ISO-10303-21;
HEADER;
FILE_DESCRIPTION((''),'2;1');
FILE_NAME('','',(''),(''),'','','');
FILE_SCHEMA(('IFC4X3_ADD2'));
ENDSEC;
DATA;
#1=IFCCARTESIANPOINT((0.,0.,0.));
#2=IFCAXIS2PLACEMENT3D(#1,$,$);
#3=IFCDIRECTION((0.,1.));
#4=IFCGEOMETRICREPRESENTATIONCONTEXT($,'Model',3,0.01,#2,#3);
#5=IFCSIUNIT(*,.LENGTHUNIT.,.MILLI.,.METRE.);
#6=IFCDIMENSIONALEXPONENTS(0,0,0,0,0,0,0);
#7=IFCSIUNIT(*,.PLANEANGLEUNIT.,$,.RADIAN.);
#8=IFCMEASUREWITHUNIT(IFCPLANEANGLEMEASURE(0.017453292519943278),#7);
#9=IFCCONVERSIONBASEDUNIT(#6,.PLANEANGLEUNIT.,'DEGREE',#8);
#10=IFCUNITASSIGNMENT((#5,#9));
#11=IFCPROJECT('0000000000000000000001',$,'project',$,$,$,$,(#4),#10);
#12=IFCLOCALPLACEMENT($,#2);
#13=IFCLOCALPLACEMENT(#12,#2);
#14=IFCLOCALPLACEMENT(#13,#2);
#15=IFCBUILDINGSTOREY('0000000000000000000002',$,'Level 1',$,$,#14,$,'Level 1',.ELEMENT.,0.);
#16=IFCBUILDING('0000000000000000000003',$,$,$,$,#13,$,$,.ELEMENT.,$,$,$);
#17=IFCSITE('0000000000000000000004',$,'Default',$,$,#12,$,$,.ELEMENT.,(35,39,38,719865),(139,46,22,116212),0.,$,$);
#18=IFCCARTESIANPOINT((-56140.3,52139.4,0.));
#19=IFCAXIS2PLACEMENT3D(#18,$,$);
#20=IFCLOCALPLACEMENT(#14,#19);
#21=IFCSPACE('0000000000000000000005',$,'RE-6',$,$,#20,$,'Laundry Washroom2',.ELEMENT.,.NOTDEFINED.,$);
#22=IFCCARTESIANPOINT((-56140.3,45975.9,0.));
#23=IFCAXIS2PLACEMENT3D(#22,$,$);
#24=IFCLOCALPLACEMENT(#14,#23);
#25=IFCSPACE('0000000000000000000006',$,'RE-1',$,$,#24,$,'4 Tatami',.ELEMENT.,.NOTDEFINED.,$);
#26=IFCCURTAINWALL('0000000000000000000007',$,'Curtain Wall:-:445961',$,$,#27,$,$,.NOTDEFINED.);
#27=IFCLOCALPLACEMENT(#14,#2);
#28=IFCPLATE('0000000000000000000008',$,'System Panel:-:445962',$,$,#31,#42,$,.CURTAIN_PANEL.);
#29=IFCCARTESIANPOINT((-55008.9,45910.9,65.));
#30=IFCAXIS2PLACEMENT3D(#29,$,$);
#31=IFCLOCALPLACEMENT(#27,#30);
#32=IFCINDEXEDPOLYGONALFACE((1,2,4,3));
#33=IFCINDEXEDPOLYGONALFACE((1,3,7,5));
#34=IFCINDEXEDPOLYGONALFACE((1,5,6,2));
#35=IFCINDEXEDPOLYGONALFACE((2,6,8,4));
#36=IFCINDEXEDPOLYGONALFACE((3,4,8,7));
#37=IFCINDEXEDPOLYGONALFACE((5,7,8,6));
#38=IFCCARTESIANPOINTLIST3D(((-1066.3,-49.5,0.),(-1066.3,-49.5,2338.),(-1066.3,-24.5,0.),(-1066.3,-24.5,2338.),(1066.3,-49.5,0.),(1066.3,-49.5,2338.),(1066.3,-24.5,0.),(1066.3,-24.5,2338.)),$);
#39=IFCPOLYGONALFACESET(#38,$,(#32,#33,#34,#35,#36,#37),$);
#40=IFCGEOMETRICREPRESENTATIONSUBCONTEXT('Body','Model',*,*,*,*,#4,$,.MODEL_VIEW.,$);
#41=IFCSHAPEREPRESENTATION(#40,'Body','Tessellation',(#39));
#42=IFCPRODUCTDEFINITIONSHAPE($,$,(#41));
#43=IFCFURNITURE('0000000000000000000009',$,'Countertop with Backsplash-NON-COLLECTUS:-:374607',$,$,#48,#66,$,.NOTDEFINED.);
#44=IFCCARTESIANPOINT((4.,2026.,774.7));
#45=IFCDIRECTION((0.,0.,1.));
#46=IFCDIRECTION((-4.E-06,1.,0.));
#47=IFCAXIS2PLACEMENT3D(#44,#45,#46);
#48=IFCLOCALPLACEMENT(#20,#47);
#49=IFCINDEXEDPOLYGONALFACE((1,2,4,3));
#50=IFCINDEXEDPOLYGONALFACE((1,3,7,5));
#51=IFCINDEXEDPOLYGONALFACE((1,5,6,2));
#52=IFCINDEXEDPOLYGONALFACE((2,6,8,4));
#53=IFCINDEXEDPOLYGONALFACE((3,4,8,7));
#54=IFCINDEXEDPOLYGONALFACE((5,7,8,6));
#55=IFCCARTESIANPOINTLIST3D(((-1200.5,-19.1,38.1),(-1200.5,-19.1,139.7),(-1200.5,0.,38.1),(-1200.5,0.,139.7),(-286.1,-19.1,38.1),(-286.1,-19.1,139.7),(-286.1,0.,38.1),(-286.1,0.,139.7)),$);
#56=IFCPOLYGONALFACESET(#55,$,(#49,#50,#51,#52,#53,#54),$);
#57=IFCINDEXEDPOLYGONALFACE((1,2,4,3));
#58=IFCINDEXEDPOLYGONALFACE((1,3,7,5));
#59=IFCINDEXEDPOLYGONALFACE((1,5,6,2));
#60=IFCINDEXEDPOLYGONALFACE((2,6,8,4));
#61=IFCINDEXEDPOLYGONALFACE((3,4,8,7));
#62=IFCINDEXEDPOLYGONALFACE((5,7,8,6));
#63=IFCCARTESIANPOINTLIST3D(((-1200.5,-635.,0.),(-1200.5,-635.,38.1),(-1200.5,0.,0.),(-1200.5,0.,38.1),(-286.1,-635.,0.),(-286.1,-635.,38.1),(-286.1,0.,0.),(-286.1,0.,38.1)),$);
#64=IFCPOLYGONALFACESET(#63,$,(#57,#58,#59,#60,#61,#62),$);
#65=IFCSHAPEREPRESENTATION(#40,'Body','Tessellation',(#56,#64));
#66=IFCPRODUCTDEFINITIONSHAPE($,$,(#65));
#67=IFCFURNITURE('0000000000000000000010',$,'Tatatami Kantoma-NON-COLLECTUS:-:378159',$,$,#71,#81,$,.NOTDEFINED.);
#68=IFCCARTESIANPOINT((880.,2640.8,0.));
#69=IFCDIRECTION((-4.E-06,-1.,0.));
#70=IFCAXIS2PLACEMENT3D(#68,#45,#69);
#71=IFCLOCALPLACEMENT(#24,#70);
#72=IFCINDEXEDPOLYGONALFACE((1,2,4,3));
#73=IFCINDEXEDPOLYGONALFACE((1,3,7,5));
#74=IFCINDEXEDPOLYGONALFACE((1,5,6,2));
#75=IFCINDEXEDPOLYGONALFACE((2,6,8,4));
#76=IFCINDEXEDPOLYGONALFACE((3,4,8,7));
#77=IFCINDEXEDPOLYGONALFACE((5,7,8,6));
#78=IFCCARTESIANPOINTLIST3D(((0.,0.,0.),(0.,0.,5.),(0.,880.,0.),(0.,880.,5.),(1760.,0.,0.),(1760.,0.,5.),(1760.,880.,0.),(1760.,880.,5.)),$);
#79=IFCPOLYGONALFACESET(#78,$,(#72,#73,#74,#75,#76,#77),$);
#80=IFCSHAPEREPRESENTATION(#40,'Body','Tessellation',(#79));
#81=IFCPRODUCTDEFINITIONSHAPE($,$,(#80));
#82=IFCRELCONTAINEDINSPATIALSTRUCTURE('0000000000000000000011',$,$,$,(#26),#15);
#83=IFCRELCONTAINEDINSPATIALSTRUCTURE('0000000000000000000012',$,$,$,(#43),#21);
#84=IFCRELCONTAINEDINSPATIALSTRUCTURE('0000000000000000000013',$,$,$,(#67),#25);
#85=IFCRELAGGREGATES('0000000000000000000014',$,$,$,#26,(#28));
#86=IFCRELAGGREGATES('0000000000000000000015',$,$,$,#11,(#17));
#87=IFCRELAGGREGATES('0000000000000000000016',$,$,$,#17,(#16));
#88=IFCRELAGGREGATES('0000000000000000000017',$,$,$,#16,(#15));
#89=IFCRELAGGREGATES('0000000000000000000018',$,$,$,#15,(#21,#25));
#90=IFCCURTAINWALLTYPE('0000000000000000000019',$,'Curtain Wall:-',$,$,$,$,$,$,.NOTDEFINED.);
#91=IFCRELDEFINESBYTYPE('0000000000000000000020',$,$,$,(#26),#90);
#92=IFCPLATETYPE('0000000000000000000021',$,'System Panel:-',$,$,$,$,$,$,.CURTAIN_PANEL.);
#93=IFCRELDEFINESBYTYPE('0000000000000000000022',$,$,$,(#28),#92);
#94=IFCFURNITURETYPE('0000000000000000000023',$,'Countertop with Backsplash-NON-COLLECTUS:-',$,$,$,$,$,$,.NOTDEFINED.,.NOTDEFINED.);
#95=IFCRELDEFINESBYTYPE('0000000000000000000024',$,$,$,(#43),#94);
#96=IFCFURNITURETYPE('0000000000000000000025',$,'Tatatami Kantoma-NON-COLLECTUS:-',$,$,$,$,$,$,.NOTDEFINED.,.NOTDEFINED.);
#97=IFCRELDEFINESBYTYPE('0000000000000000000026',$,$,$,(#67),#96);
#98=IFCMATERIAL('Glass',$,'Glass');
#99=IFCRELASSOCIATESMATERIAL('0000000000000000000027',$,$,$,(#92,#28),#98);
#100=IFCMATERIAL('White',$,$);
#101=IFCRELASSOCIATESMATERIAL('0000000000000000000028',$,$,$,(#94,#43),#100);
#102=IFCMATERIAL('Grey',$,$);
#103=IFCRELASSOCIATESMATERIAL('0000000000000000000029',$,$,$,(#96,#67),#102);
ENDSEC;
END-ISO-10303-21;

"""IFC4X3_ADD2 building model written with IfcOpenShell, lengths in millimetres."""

from ifc_helpers import new_model, entity, si_unit, converted_unit, direction, frame, frame_2d, origin, origin_2d_with_axis, place, context, subcontext, project, spatial, rectangle, extrude, source, transform, mapped, material, type_object, type_shapes, element, aggregate, save


model = new_model("IFC4X3_ADD2")

# Units and contexts
model_context = context("Model", 3, precision=0.01, world=origin(), true_north=direction((0.0, 1.0)))
body_context = subcontext(model_context, "Body", "Model", "MODEL_VIEW")
ifc_project = project(units=[si_unit("LENGTHUNIT", "METRE", prefix="MILLI"), converted_unit("PLANEANGLEUNIT", "DEGREE", entity("IfcPlaneAngleMeasure", 0.017453292519943278), si_unit("PLANEANGLEUNIT", "RADIAN"), dimensions=[0, 0, 0, 0, 0, 0, 0])], contexts=[model_context])

# Site, building, storey
site_placement = place(None, origin())
site = spatial("IfcSite", under=ifc_project, at=site_placement, Name="Default", CompositionType="ELEMENT", RefLatitude=(35, 39, 38, 719865), RefLongitude=(139, 46, 22, 116212), RefElevation=0.0)
building_placement = place(site_placement, origin())
building = spatial("IfcBuilding", under=site, at=building_placement, CompositionType="ELEMENT")
storey_placement = place(building_placement, origin())
storey = spatial("IfcBuildingStorey", under=building, at=storey_placement, Name="Level 1", LongName="Level 1", CompositionType="ELEMENT", Elevation=0.0)

# Curtain wall, plate
curtain_wall_type = type_object("IfcCurtainWallType", Name="Curtain Wall:-", PredefinedType="NOTDEFINED")
curtain_wall_placement = place(storey_placement, origin())
curtain_wall = element("IfcCurtainWall", 1, at=curtain_wall_placement, inside=storey, type_object=curtain_wall_type, Name="Curtain Wall:-:445961", PredefinedType="NOTDEFINED")
ifc_material_1 = material(Name="Glass", Category="Glass")
plate_type = type_object("IfcPlateType", Name="System Panel:-", PredefinedType="CURTAIN_PANEL", material=ifc_material_1)
shared_shape_1 = source(origin(), body_context, "Body", "SweptSolid", [
    extrude(rectangle(XDim=25.0, YDim=2132.6, at=frame_2d((0.0, 0.0), x_axis=(1.0, 0.0))), frame((0.0, -37.0, 0.0), z_axis=(0.0, 0.0, 1.0), x_axis=(0.0, 1.0, 0.0)), (0.0, 0.0, 1.0), 2338.0),
])
type_shapes(plate_type, [shared_shape_1])
plate_placement = place(curtain_wall_placement, frame((-55008.9, 45910.9, 65.0)))
plate = element("IfcPlate", 2, at=plate_placement, type_object=plate_type, material=ifc_material_1, Name="System Panel:-:445962", PredefinedType="CURTAIN_PANEL", context=body_context, shape_type="MappedRepresentation", body=[
    mapped(shared_shape_1, transform((0.0, 0.0, 0.0), scale=1.0)),
])
aggregate(curtain_wall, [plate])

# Shared definitions
space_1_placement = place(storey_placement, frame((-56140.3, 52139.4, 0.0)))
space_1 = spatial("IfcSpace", under=storey, at=space_1_placement, Name="RE-6", LongName="Laundry Washroom2", CompositionType="ELEMENT", PredefinedType="NOTDEFINED")

# Shared definitions
ifc_material_2 = material(Name="White")

# Furniture
furniture_type_1 = type_object("IfcFurnitureType", Name="Countertop with Backsplash-NON-COLLECTUS:-", AssemblyPlace="NOTDEFINED", PredefinedType="NOTDEFINED", material=ifc_material_2)
shared_shape_2 = source(origin(), body_context, "Body", "SweptSolid", [
    extrude(rectangle(XDim=19.1, YDim=914.4, at=frame_2d((0.0, 0.0), x_axis=(1.0, 0.0))), frame((-743.3, -9.5, 38.1), z_axis=(0.0, 0.0, 1.0), x_axis=(0.0, -1.0, 0.0)), (0.0, 0.0, 1.0), 101.6),
    extrude(rectangle(XDim=914.4, YDim=635.0, at=frame_2d((0.0, 0.0), x_axis=(1.0, 0.0))), frame((-743.3, -317.5, 0.0), z_axis=(0.0, 0.0, 1.0), x_axis=(-1.0, 0.0, 0.0)), (0.0, 0.0, 1.0), 38.1),
])
type_shapes(furniture_type_1, [shared_shape_2])
furniture_1_placement = place(space_1_placement, frame((4.0, 2026.0, 774.7), z_axis=(0.0, 0.0, 1.0), x_axis=(-0.000004, 1.0, 0.0)))
element("IfcFurniture", 3, at=furniture_1_placement, inside=space_1, type_object=furniture_type_1, material=ifc_material_2, Name="Countertop with Backsplash-NON-COLLECTUS:-:374607", PredefinedType="NOTDEFINED", context=body_context, shape_type="MappedRepresentation", body=[
    mapped(shared_shape_2, transform((0.0, 0.0, 0.0), scale=1.0)),
])

# Shared definitions
space_2_placement = place(storey_placement, frame((-56140.3, 45975.9, 0.0)))
space_2 = spatial("IfcSpace", under=storey, at=space_2_placement, Name="RE-1", LongName="4 Tatami", CompositionType="ELEMENT", PredefinedType="NOTDEFINED")

# Furniture
ifc_material_3 = material(Name="Grey")
furniture_type_2 = type_object("IfcFurnitureType", Name="Tatatami Kantoma-NON-COLLECTUS:-", AssemblyPlace="NOTDEFINED", PredefinedType="NOTDEFINED", material=ifc_material_3)
shared_shape_3 = source(origin(), body_context, "Body", "SweptSolid", [
    extrude(rectangle(XDim=1760.0, YDim=880.0, at=origin_2d_with_axis()), frame((880.0, 440.0, 0.0), z_axis=(0.0, 0.0, 1.0), x_axis=(-1.0, 0.0, 0.0)), (0.0, 0.0, 1.0), 5.0),
])
type_shapes(furniture_type_2, [shared_shape_3])
for number, where, z_axis, x_axis, name in (
    (4, (880.0, 2640.8, 0.0), (0.0, 0.0, 1.0), (-0.000004, -1.0, 0.0), "Tatatami Kantoma-NON-COLLECTUS:-:378159"),
):
    element("IfcFurniture", number, at=place(space_2_placement, frame(where, z_axis=z_axis, x_axis=x_axis)), inside=space_2, type_object=furniture_type_2, material=ifc_material_3, Name=name, PredefinedType="NOTDEFINED", context=body_context, shape_type="MappedRepresentation", body=[
        mapped(shared_shape_3, transform((0.0, 0.0, 0.0), scale=1.0)),
    ])

save(model, "model.ifc")
